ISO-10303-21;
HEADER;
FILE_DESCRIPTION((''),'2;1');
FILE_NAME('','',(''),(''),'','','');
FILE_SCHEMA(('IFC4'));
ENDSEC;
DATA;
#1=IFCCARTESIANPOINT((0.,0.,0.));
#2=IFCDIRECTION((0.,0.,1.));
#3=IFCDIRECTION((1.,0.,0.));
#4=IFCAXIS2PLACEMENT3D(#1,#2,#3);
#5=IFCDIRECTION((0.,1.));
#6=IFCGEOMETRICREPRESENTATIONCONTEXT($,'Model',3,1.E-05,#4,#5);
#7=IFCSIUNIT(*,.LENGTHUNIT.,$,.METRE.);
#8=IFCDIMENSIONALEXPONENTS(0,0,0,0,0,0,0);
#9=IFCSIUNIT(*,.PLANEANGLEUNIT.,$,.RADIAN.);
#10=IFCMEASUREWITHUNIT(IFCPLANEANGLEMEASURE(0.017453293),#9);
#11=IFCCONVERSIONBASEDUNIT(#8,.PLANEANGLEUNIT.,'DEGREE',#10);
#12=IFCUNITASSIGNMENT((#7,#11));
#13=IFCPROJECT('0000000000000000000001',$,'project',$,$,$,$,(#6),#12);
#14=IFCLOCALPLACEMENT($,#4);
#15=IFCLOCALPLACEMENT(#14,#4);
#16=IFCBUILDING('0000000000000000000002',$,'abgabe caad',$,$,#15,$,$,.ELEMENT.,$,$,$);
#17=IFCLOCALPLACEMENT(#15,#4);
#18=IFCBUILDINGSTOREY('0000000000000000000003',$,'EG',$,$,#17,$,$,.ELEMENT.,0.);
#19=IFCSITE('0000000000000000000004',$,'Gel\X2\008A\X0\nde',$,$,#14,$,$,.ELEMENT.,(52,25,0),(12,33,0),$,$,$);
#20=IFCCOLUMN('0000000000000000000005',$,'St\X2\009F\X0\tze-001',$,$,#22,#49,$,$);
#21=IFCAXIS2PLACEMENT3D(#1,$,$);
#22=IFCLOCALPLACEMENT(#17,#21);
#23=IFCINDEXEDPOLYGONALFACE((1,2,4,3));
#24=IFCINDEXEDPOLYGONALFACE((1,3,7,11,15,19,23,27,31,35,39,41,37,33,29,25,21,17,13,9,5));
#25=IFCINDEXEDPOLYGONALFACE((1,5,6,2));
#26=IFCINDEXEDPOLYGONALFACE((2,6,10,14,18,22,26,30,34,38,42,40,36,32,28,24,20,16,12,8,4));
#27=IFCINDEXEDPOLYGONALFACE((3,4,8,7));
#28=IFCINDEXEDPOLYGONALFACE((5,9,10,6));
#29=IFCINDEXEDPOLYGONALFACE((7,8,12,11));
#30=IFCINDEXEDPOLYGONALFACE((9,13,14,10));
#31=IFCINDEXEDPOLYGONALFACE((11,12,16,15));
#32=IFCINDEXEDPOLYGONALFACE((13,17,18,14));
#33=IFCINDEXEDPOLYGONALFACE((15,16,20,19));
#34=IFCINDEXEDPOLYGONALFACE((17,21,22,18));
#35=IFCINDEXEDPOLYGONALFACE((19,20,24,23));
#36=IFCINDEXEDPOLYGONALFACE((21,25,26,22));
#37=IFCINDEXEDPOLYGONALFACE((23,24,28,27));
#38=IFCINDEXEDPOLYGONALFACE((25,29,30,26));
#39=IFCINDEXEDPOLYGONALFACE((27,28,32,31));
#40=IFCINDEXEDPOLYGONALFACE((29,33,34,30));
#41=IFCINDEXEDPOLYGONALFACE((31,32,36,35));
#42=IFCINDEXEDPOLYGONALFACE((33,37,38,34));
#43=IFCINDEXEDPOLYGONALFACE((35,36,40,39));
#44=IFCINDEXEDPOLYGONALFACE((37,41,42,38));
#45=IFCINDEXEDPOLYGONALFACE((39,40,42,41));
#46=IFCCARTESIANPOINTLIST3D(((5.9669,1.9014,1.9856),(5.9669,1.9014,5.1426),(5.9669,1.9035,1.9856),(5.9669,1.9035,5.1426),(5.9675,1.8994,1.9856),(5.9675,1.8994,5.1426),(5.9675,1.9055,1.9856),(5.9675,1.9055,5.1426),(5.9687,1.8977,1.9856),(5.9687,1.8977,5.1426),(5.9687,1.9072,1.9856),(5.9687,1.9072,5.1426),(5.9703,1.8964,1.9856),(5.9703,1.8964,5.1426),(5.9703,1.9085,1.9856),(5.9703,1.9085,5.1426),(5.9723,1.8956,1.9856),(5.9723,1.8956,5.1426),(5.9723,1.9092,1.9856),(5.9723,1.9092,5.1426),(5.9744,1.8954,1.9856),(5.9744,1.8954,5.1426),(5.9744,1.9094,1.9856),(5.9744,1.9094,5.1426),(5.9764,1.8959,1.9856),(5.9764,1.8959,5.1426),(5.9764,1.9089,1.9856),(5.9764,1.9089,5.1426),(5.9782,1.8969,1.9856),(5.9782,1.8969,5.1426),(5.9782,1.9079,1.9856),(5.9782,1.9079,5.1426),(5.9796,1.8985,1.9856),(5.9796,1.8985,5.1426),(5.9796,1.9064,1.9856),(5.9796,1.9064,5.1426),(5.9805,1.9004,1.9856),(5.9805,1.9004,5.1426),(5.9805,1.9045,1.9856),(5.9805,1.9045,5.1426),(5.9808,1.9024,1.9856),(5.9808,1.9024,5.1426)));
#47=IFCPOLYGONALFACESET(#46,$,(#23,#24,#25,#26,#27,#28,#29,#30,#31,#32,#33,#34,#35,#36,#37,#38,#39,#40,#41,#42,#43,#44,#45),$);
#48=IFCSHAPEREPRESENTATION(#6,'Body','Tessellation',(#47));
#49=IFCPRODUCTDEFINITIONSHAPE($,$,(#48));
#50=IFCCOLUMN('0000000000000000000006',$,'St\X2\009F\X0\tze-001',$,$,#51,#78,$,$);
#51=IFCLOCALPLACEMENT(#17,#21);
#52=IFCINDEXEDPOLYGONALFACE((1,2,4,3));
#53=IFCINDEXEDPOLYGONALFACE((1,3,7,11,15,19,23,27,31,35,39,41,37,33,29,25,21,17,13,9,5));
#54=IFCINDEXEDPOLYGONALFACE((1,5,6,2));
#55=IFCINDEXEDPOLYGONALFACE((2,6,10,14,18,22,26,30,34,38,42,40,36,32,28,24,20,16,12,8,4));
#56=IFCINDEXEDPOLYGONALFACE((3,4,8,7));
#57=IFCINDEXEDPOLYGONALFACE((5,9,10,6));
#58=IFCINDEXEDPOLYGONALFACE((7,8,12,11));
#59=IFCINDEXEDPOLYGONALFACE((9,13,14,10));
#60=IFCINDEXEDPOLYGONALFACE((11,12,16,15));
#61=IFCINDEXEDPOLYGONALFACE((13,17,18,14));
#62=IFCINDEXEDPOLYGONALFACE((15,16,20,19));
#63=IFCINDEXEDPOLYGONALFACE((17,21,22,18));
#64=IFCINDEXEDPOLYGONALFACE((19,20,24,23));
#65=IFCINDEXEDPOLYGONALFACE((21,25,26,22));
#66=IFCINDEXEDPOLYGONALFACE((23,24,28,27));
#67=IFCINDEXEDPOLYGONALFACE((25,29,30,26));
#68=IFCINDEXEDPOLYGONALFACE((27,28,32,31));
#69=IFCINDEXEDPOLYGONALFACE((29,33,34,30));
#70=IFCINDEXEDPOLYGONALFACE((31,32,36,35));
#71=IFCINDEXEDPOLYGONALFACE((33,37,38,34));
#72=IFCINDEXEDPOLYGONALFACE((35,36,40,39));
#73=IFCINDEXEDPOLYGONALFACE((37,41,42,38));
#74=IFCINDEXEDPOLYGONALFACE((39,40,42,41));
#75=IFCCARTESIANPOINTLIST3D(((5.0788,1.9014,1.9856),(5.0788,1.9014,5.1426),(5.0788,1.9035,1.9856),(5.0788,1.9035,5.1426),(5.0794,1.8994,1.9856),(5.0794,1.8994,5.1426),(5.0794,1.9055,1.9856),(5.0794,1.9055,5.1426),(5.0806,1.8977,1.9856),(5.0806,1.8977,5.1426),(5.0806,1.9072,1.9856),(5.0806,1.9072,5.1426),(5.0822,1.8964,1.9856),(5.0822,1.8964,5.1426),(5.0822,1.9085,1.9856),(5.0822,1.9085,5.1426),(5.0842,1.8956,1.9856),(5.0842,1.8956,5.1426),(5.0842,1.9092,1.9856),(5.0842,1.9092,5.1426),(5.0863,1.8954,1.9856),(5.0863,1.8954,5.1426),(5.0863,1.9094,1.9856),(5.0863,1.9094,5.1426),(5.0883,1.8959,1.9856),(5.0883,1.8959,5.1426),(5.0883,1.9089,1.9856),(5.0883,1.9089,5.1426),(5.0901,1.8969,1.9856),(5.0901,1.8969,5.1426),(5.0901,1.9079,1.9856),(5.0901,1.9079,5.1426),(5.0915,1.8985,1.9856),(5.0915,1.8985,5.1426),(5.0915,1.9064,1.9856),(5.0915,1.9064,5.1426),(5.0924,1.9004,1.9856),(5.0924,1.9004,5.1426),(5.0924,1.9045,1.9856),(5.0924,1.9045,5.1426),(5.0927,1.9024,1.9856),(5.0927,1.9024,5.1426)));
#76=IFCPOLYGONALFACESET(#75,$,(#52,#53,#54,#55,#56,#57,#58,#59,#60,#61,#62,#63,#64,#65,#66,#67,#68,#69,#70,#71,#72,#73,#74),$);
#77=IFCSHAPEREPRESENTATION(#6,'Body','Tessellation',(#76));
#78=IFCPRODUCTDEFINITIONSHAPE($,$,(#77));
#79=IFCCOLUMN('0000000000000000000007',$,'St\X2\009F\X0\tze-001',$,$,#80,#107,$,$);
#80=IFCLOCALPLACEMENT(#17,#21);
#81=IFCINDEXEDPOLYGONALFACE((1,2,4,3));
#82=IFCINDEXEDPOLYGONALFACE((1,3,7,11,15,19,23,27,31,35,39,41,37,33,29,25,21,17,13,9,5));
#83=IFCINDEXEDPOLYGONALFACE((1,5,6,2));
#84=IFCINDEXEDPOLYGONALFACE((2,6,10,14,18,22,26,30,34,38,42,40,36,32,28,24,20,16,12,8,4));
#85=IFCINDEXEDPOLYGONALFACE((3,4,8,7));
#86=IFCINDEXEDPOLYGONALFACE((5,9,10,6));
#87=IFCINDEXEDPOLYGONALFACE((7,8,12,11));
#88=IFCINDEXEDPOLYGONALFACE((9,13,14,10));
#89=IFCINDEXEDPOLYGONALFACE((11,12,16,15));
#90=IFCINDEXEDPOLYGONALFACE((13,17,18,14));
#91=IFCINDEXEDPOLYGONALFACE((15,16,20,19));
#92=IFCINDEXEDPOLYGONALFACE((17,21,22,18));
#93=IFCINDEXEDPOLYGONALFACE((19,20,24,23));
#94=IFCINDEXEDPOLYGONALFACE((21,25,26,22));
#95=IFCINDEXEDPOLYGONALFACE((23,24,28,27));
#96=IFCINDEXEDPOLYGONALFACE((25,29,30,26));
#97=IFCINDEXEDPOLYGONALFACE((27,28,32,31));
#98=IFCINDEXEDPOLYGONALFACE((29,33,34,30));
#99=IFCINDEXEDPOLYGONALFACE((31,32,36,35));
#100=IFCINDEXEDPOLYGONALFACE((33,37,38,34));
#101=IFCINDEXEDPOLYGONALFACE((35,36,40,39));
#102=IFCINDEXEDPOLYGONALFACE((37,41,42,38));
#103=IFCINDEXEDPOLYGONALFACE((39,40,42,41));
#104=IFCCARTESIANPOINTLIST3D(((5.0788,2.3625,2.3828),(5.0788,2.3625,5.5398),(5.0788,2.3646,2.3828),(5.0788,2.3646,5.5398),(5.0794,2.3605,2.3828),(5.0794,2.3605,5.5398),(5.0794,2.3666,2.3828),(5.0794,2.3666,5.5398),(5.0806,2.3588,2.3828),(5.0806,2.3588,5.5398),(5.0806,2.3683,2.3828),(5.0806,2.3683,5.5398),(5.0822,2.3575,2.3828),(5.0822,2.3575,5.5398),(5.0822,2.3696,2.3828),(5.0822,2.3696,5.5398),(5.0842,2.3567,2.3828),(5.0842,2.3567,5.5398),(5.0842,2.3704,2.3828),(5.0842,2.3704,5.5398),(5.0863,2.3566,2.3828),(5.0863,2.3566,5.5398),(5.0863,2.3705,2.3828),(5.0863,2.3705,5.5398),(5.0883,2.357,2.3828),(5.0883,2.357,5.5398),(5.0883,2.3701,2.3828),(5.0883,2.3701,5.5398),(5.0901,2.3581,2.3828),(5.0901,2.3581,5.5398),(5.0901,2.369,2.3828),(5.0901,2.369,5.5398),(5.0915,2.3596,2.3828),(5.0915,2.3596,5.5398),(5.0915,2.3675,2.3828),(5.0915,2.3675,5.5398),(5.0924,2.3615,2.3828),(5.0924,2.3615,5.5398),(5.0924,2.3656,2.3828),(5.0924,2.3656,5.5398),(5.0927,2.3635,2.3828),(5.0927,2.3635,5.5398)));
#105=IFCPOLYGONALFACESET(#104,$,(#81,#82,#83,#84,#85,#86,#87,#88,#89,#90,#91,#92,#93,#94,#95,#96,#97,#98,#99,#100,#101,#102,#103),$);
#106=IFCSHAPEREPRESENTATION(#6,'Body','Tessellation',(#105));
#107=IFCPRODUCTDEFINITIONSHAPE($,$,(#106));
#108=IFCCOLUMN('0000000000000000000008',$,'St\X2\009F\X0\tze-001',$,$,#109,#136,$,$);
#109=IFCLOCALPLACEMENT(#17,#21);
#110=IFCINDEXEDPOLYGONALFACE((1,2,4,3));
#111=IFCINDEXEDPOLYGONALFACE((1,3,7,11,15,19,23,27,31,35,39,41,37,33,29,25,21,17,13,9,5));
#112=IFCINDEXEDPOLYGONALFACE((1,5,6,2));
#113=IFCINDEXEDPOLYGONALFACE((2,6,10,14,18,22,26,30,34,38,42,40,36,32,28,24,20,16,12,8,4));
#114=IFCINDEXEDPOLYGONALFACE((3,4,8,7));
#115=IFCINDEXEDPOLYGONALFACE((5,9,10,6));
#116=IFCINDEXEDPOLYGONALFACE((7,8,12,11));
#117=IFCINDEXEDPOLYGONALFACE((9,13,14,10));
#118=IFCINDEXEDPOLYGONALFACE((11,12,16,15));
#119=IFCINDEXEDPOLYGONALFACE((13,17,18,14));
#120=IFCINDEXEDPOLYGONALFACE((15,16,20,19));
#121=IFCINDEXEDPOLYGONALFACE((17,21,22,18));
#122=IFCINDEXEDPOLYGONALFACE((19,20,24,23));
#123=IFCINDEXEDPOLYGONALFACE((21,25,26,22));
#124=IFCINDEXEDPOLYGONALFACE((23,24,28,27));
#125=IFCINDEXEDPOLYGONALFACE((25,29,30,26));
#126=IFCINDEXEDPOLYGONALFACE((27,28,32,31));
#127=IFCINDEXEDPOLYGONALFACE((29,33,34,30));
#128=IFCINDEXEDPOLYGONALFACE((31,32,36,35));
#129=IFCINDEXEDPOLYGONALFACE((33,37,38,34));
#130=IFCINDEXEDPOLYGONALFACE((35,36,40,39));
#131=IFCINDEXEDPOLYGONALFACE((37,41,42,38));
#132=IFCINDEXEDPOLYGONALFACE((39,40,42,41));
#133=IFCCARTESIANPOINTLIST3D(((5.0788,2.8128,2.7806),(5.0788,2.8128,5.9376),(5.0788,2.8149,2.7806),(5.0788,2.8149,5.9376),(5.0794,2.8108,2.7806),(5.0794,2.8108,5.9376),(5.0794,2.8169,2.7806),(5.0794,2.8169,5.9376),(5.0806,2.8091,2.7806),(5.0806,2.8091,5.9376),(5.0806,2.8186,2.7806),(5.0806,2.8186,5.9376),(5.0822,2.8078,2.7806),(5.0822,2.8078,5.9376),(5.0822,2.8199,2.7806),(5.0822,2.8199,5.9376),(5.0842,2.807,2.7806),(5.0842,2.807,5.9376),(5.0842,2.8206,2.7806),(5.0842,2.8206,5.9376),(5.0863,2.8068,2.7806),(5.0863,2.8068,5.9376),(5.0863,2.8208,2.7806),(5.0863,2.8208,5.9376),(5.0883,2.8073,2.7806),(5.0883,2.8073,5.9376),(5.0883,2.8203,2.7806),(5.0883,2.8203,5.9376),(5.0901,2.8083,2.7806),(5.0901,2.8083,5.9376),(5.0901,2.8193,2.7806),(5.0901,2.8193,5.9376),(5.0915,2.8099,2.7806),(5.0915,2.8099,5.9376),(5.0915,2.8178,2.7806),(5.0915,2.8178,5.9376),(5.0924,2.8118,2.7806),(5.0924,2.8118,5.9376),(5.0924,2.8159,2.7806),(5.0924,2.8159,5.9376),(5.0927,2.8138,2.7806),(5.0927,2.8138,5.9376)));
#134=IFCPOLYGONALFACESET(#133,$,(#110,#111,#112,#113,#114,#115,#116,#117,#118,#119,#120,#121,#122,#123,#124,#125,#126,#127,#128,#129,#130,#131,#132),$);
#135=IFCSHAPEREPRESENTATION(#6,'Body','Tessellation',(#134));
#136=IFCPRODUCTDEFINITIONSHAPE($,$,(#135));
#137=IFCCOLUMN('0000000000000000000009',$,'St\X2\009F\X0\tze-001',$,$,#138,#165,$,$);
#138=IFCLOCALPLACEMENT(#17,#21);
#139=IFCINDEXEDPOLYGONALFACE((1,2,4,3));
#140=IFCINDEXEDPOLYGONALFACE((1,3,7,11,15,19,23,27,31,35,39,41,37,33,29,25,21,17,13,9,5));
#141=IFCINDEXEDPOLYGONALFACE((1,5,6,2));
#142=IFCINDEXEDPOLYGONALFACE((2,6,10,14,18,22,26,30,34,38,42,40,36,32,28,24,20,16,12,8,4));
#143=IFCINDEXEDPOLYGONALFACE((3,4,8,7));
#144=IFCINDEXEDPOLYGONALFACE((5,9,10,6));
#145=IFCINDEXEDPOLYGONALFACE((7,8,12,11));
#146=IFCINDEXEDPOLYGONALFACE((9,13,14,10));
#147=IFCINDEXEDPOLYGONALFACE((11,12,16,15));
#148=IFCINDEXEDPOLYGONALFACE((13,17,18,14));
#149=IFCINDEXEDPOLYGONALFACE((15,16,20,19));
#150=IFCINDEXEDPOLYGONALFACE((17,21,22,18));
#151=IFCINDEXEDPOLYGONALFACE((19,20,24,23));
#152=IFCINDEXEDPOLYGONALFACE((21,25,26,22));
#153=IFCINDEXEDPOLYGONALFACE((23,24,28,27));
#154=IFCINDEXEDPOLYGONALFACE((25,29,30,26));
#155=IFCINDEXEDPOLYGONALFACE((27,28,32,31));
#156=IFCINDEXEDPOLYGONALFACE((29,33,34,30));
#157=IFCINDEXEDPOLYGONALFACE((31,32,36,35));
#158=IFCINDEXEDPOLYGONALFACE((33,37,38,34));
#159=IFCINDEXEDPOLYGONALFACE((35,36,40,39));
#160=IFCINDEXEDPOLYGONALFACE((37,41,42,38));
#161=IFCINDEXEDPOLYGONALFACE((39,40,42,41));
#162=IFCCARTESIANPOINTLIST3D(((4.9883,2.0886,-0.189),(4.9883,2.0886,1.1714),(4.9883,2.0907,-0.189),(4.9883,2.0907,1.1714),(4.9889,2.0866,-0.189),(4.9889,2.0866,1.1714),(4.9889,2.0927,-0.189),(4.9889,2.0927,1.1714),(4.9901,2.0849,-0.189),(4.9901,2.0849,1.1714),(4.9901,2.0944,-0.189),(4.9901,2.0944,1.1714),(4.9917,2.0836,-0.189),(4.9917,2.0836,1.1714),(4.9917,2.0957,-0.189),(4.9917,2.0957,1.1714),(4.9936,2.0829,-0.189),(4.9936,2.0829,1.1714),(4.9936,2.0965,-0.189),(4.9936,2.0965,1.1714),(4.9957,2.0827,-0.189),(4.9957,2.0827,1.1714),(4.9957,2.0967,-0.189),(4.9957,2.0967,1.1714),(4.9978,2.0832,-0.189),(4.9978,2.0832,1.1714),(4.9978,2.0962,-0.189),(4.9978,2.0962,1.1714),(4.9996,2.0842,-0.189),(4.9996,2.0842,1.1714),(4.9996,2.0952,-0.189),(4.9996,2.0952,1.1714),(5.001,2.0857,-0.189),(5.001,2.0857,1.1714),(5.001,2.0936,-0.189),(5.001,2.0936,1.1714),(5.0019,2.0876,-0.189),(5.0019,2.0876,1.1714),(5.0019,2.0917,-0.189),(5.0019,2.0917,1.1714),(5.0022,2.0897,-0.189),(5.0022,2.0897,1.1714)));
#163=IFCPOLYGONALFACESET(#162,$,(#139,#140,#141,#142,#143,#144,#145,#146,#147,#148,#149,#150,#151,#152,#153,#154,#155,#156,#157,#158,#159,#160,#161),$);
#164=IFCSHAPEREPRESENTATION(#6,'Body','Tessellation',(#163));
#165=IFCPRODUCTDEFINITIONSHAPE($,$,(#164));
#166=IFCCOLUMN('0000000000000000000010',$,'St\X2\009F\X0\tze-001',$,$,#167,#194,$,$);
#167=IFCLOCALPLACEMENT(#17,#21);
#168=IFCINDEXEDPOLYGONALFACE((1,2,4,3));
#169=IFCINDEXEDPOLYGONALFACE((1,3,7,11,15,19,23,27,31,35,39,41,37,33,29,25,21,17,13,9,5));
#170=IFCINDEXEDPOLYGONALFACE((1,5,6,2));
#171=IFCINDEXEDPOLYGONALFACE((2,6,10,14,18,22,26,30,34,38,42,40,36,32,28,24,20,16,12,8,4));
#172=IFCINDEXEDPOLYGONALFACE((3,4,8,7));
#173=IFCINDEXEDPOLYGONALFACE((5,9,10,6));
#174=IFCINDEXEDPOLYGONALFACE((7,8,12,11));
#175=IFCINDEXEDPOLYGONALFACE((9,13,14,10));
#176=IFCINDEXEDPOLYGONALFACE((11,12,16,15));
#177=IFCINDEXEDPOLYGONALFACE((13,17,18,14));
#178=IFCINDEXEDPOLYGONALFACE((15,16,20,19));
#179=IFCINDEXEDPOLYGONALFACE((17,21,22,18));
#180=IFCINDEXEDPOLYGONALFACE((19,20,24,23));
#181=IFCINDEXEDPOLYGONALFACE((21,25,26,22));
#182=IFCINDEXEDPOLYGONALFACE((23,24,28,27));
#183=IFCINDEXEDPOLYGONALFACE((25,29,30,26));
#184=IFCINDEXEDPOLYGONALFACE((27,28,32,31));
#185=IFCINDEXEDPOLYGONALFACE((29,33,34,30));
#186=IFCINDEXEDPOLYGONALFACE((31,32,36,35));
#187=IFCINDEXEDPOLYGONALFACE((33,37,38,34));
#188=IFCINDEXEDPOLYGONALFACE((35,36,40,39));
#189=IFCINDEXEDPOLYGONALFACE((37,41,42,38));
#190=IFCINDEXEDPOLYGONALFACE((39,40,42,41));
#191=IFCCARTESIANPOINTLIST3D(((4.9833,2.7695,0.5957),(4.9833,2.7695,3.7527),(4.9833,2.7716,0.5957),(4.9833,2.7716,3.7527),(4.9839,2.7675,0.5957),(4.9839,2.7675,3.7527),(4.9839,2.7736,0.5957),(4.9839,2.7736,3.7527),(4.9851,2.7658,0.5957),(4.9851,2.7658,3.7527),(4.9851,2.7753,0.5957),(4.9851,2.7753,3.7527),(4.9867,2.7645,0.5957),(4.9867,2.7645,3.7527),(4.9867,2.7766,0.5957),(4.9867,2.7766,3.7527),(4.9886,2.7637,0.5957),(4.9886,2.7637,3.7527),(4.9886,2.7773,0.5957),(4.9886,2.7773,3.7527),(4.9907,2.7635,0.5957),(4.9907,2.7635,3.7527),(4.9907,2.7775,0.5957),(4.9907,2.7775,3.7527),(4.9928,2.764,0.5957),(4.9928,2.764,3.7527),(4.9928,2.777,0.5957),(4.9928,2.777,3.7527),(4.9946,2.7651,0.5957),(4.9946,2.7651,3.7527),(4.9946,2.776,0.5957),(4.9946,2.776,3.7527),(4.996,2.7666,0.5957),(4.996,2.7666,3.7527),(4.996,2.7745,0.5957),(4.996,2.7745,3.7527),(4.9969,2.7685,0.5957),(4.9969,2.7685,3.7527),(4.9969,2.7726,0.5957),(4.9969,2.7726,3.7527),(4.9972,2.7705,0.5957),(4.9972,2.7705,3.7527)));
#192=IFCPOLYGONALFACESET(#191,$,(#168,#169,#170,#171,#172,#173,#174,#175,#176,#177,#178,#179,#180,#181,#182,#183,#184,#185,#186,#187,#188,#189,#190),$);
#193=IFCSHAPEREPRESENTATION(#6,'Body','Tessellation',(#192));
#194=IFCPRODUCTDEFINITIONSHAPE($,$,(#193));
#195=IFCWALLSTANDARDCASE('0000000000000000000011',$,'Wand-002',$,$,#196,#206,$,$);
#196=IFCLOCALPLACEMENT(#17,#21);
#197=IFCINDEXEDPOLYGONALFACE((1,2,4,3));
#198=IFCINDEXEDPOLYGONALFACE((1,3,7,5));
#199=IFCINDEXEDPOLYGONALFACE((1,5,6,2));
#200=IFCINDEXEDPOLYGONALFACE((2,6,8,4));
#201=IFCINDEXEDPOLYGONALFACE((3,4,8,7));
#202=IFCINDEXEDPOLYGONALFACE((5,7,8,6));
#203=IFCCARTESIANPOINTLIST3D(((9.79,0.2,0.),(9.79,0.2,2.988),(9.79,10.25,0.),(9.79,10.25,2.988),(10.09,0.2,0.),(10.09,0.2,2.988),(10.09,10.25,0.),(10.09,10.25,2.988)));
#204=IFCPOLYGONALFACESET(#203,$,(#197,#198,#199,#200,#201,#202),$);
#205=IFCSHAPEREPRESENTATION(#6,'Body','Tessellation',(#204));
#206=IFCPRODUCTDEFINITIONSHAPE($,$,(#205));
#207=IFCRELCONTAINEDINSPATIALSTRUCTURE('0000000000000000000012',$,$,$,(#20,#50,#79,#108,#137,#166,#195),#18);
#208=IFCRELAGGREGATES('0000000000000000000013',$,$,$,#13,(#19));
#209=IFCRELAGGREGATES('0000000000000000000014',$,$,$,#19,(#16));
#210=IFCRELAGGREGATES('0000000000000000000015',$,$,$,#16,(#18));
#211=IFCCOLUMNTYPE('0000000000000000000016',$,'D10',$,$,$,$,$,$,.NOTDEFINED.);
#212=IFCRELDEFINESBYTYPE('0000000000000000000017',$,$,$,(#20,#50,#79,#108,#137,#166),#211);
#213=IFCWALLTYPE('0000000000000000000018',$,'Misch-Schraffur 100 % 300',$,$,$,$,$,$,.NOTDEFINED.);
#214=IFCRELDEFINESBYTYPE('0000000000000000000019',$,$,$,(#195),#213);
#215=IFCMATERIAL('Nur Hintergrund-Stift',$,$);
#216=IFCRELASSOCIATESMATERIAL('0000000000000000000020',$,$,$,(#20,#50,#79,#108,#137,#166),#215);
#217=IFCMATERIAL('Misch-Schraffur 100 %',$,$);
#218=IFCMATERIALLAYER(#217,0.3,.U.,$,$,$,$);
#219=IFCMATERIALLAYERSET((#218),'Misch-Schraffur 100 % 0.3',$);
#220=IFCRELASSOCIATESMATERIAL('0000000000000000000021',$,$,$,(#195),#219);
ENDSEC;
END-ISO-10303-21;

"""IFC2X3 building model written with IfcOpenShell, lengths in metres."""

from ifc_helpers import new_model, entity, si_unit, converted_unit, direction, frame, origin_with_axes, origin_2d_with_axis, place, context, project, spatial, polyline, circle, outline, extrude, material, layer, layer_set, layer_usage, type_object, element, save


model = new_model("IFC2X3")

# Units and contexts
model_context = context("Model", 3, precision=1e-05, world=origin_with_axes(), true_north=direction((0.0, 1.0)))
ifc_project = project(units=[si_unit("LENGTHUNIT", "METRE"), converted_unit("PLANEANGLEUNIT", "DEGREE", entity("IfcPlaneAngleMeasure", 0.017453293), si_unit("PLANEANGLEUNIT", "RADIAN"), dimensions=[0, 0, 0, 0, 0, 0, 0])], contexts=[model_context])

# Site, building, storey
site_placement = place(None, origin_with_axes())
site = spatial("IfcSite", under=ifc_project, at=site_placement, Name="Gel\u008ande", CompositionType="ELEMENT", RefLatitude=(52, 25, 0), RefLongitude=(12, 33, 0))
building_placement = place(site_placement, origin_with_axes())
building = spatial("IfcBuilding", under=site, at=building_placement, Name="abgabe caad", CompositionType="ELEMENT")
storey_placement = place(building_placement, origin_with_axes())
storey = spatial("IfcBuildingStorey", under=building, at=storey_placement, Name="EG", CompositionType="ELEMENT", Elevation=0.0)

# Columns
ifc_material_1 = material(Name="Nur Hintergrund-Stift")
column_type = type_object("IfcColumnType", Name="D10", PredefinedType="NOTDEFINED")
for number, where, z_axis, x_axis, name in (
    (1, (5.9738, 1.9024, 1.9856), (0.0, 0.0, 1.0), (1.0, 0.0, 0.0), "St\u009ftze-001"),
    (2, (5.0857, 1.9024, 1.9856), (0.0, 0.0, 1.0), (1.0, 0.0, 0.0), "St\u009ftze-001"),
    (3, (5.0857, 2.3635, 2.3828), (0.0, 0.0, 1.0), (1.0, 0.0, 0.0), "St\u009ftze-001"),
    (4, (5.0857, 2.8138, 2.7806), (0.0, 0.0, 1.0), (1.0, 0.0, 0.0), "St\u009ftze-001"),
):
    element("IfcColumn", number, at=place(storey_placement, frame(where, z_axis=z_axis, x_axis=x_axis)), inside=storey, type_object=column_type, material=ifc_material_1, Name=name, context=model_context, shape_type="SweptSolid", body=[
        extrude(circle(Radius=0.007, at=origin_2d_with_axis()), origin_with_axes(), (0.0, 0.0, 1.0), 3.157),
    ])
column_1_placement = place(storey_placement, frame((4.9952, 2.0897, -0.189), z_axis=(0.0, 0.0, 1.0), x_axis=(1.0, 0.0, 0.0)))
element("IfcColumn", 5, at=column_1_placement, inside=storey, type_object=column_type, material=ifc_material_1, Name="St\u009ftze-001", context=model_context, shape_type="SweptSolid", body=[
    extrude(circle(Radius=0.007, at=origin_2d_with_axis()), origin_with_axes(), (0.0, 0.0, 1.0), 1.3604),
])
column_2_placement = place(storey_placement, frame((4.9902, 2.7705, 0.5957), z_axis=(0.0, 0.0, 1.0), x_axis=(1.0, 0.0, 0.0)))
element("IfcColumn", 6, at=column_2_placement, inside=storey, type_object=column_type, material=ifc_material_1, Name="St\u009ftze-001", context=model_context, shape_type="SweptSolid", body=[
    extrude(circle(Radius=0.007, at=origin_2d_with_axis()), origin_with_axes(), (0.0, 0.0, 1.0), 3.157),
])

# Wall
ifc_material_2 = material(Name="Misch-Schraffur 100 %")
ifc_layer = layer(ifc_material_2, 0.3, ventilated="UNKNOWN")
ifc_layer_set = layer_set([ifc_layer], Name="Misch-Schraffur 100 % 0.3")
ifc_layer_usage = layer_usage(ifc_layer_set, "AXIS2", "NEGATIVE", 0.0)
wall_type = type_object("IfcWallType", Name="Misch-Schraffur 100 % 300", PredefinedType="NOTDEFINED")
wall_placement = place(storey_placement, frame((9.79, 0.0, 0.0), z_axis=(0.0, 0.0, 1.0), x_axis=(0.0, 1.0, 0.0)))
element("IfcWallStandardCase", 7, at=wall_placement, inside=storey, type_object=wall_type, material=ifc_layer_usage, Name="Wand-002", context=model_context, shape_type="SweptSolid", body=[
    extrude(outline(polyline([(0.2, -0.3), (10.25, -0.3), (10.25, 0.0), (0.2, 0.0), (0.2, -0.3)])), origin_with_axes(), (0.0, 0.0, 1.0), 2.988),
])

save(model, "model.ifc")
